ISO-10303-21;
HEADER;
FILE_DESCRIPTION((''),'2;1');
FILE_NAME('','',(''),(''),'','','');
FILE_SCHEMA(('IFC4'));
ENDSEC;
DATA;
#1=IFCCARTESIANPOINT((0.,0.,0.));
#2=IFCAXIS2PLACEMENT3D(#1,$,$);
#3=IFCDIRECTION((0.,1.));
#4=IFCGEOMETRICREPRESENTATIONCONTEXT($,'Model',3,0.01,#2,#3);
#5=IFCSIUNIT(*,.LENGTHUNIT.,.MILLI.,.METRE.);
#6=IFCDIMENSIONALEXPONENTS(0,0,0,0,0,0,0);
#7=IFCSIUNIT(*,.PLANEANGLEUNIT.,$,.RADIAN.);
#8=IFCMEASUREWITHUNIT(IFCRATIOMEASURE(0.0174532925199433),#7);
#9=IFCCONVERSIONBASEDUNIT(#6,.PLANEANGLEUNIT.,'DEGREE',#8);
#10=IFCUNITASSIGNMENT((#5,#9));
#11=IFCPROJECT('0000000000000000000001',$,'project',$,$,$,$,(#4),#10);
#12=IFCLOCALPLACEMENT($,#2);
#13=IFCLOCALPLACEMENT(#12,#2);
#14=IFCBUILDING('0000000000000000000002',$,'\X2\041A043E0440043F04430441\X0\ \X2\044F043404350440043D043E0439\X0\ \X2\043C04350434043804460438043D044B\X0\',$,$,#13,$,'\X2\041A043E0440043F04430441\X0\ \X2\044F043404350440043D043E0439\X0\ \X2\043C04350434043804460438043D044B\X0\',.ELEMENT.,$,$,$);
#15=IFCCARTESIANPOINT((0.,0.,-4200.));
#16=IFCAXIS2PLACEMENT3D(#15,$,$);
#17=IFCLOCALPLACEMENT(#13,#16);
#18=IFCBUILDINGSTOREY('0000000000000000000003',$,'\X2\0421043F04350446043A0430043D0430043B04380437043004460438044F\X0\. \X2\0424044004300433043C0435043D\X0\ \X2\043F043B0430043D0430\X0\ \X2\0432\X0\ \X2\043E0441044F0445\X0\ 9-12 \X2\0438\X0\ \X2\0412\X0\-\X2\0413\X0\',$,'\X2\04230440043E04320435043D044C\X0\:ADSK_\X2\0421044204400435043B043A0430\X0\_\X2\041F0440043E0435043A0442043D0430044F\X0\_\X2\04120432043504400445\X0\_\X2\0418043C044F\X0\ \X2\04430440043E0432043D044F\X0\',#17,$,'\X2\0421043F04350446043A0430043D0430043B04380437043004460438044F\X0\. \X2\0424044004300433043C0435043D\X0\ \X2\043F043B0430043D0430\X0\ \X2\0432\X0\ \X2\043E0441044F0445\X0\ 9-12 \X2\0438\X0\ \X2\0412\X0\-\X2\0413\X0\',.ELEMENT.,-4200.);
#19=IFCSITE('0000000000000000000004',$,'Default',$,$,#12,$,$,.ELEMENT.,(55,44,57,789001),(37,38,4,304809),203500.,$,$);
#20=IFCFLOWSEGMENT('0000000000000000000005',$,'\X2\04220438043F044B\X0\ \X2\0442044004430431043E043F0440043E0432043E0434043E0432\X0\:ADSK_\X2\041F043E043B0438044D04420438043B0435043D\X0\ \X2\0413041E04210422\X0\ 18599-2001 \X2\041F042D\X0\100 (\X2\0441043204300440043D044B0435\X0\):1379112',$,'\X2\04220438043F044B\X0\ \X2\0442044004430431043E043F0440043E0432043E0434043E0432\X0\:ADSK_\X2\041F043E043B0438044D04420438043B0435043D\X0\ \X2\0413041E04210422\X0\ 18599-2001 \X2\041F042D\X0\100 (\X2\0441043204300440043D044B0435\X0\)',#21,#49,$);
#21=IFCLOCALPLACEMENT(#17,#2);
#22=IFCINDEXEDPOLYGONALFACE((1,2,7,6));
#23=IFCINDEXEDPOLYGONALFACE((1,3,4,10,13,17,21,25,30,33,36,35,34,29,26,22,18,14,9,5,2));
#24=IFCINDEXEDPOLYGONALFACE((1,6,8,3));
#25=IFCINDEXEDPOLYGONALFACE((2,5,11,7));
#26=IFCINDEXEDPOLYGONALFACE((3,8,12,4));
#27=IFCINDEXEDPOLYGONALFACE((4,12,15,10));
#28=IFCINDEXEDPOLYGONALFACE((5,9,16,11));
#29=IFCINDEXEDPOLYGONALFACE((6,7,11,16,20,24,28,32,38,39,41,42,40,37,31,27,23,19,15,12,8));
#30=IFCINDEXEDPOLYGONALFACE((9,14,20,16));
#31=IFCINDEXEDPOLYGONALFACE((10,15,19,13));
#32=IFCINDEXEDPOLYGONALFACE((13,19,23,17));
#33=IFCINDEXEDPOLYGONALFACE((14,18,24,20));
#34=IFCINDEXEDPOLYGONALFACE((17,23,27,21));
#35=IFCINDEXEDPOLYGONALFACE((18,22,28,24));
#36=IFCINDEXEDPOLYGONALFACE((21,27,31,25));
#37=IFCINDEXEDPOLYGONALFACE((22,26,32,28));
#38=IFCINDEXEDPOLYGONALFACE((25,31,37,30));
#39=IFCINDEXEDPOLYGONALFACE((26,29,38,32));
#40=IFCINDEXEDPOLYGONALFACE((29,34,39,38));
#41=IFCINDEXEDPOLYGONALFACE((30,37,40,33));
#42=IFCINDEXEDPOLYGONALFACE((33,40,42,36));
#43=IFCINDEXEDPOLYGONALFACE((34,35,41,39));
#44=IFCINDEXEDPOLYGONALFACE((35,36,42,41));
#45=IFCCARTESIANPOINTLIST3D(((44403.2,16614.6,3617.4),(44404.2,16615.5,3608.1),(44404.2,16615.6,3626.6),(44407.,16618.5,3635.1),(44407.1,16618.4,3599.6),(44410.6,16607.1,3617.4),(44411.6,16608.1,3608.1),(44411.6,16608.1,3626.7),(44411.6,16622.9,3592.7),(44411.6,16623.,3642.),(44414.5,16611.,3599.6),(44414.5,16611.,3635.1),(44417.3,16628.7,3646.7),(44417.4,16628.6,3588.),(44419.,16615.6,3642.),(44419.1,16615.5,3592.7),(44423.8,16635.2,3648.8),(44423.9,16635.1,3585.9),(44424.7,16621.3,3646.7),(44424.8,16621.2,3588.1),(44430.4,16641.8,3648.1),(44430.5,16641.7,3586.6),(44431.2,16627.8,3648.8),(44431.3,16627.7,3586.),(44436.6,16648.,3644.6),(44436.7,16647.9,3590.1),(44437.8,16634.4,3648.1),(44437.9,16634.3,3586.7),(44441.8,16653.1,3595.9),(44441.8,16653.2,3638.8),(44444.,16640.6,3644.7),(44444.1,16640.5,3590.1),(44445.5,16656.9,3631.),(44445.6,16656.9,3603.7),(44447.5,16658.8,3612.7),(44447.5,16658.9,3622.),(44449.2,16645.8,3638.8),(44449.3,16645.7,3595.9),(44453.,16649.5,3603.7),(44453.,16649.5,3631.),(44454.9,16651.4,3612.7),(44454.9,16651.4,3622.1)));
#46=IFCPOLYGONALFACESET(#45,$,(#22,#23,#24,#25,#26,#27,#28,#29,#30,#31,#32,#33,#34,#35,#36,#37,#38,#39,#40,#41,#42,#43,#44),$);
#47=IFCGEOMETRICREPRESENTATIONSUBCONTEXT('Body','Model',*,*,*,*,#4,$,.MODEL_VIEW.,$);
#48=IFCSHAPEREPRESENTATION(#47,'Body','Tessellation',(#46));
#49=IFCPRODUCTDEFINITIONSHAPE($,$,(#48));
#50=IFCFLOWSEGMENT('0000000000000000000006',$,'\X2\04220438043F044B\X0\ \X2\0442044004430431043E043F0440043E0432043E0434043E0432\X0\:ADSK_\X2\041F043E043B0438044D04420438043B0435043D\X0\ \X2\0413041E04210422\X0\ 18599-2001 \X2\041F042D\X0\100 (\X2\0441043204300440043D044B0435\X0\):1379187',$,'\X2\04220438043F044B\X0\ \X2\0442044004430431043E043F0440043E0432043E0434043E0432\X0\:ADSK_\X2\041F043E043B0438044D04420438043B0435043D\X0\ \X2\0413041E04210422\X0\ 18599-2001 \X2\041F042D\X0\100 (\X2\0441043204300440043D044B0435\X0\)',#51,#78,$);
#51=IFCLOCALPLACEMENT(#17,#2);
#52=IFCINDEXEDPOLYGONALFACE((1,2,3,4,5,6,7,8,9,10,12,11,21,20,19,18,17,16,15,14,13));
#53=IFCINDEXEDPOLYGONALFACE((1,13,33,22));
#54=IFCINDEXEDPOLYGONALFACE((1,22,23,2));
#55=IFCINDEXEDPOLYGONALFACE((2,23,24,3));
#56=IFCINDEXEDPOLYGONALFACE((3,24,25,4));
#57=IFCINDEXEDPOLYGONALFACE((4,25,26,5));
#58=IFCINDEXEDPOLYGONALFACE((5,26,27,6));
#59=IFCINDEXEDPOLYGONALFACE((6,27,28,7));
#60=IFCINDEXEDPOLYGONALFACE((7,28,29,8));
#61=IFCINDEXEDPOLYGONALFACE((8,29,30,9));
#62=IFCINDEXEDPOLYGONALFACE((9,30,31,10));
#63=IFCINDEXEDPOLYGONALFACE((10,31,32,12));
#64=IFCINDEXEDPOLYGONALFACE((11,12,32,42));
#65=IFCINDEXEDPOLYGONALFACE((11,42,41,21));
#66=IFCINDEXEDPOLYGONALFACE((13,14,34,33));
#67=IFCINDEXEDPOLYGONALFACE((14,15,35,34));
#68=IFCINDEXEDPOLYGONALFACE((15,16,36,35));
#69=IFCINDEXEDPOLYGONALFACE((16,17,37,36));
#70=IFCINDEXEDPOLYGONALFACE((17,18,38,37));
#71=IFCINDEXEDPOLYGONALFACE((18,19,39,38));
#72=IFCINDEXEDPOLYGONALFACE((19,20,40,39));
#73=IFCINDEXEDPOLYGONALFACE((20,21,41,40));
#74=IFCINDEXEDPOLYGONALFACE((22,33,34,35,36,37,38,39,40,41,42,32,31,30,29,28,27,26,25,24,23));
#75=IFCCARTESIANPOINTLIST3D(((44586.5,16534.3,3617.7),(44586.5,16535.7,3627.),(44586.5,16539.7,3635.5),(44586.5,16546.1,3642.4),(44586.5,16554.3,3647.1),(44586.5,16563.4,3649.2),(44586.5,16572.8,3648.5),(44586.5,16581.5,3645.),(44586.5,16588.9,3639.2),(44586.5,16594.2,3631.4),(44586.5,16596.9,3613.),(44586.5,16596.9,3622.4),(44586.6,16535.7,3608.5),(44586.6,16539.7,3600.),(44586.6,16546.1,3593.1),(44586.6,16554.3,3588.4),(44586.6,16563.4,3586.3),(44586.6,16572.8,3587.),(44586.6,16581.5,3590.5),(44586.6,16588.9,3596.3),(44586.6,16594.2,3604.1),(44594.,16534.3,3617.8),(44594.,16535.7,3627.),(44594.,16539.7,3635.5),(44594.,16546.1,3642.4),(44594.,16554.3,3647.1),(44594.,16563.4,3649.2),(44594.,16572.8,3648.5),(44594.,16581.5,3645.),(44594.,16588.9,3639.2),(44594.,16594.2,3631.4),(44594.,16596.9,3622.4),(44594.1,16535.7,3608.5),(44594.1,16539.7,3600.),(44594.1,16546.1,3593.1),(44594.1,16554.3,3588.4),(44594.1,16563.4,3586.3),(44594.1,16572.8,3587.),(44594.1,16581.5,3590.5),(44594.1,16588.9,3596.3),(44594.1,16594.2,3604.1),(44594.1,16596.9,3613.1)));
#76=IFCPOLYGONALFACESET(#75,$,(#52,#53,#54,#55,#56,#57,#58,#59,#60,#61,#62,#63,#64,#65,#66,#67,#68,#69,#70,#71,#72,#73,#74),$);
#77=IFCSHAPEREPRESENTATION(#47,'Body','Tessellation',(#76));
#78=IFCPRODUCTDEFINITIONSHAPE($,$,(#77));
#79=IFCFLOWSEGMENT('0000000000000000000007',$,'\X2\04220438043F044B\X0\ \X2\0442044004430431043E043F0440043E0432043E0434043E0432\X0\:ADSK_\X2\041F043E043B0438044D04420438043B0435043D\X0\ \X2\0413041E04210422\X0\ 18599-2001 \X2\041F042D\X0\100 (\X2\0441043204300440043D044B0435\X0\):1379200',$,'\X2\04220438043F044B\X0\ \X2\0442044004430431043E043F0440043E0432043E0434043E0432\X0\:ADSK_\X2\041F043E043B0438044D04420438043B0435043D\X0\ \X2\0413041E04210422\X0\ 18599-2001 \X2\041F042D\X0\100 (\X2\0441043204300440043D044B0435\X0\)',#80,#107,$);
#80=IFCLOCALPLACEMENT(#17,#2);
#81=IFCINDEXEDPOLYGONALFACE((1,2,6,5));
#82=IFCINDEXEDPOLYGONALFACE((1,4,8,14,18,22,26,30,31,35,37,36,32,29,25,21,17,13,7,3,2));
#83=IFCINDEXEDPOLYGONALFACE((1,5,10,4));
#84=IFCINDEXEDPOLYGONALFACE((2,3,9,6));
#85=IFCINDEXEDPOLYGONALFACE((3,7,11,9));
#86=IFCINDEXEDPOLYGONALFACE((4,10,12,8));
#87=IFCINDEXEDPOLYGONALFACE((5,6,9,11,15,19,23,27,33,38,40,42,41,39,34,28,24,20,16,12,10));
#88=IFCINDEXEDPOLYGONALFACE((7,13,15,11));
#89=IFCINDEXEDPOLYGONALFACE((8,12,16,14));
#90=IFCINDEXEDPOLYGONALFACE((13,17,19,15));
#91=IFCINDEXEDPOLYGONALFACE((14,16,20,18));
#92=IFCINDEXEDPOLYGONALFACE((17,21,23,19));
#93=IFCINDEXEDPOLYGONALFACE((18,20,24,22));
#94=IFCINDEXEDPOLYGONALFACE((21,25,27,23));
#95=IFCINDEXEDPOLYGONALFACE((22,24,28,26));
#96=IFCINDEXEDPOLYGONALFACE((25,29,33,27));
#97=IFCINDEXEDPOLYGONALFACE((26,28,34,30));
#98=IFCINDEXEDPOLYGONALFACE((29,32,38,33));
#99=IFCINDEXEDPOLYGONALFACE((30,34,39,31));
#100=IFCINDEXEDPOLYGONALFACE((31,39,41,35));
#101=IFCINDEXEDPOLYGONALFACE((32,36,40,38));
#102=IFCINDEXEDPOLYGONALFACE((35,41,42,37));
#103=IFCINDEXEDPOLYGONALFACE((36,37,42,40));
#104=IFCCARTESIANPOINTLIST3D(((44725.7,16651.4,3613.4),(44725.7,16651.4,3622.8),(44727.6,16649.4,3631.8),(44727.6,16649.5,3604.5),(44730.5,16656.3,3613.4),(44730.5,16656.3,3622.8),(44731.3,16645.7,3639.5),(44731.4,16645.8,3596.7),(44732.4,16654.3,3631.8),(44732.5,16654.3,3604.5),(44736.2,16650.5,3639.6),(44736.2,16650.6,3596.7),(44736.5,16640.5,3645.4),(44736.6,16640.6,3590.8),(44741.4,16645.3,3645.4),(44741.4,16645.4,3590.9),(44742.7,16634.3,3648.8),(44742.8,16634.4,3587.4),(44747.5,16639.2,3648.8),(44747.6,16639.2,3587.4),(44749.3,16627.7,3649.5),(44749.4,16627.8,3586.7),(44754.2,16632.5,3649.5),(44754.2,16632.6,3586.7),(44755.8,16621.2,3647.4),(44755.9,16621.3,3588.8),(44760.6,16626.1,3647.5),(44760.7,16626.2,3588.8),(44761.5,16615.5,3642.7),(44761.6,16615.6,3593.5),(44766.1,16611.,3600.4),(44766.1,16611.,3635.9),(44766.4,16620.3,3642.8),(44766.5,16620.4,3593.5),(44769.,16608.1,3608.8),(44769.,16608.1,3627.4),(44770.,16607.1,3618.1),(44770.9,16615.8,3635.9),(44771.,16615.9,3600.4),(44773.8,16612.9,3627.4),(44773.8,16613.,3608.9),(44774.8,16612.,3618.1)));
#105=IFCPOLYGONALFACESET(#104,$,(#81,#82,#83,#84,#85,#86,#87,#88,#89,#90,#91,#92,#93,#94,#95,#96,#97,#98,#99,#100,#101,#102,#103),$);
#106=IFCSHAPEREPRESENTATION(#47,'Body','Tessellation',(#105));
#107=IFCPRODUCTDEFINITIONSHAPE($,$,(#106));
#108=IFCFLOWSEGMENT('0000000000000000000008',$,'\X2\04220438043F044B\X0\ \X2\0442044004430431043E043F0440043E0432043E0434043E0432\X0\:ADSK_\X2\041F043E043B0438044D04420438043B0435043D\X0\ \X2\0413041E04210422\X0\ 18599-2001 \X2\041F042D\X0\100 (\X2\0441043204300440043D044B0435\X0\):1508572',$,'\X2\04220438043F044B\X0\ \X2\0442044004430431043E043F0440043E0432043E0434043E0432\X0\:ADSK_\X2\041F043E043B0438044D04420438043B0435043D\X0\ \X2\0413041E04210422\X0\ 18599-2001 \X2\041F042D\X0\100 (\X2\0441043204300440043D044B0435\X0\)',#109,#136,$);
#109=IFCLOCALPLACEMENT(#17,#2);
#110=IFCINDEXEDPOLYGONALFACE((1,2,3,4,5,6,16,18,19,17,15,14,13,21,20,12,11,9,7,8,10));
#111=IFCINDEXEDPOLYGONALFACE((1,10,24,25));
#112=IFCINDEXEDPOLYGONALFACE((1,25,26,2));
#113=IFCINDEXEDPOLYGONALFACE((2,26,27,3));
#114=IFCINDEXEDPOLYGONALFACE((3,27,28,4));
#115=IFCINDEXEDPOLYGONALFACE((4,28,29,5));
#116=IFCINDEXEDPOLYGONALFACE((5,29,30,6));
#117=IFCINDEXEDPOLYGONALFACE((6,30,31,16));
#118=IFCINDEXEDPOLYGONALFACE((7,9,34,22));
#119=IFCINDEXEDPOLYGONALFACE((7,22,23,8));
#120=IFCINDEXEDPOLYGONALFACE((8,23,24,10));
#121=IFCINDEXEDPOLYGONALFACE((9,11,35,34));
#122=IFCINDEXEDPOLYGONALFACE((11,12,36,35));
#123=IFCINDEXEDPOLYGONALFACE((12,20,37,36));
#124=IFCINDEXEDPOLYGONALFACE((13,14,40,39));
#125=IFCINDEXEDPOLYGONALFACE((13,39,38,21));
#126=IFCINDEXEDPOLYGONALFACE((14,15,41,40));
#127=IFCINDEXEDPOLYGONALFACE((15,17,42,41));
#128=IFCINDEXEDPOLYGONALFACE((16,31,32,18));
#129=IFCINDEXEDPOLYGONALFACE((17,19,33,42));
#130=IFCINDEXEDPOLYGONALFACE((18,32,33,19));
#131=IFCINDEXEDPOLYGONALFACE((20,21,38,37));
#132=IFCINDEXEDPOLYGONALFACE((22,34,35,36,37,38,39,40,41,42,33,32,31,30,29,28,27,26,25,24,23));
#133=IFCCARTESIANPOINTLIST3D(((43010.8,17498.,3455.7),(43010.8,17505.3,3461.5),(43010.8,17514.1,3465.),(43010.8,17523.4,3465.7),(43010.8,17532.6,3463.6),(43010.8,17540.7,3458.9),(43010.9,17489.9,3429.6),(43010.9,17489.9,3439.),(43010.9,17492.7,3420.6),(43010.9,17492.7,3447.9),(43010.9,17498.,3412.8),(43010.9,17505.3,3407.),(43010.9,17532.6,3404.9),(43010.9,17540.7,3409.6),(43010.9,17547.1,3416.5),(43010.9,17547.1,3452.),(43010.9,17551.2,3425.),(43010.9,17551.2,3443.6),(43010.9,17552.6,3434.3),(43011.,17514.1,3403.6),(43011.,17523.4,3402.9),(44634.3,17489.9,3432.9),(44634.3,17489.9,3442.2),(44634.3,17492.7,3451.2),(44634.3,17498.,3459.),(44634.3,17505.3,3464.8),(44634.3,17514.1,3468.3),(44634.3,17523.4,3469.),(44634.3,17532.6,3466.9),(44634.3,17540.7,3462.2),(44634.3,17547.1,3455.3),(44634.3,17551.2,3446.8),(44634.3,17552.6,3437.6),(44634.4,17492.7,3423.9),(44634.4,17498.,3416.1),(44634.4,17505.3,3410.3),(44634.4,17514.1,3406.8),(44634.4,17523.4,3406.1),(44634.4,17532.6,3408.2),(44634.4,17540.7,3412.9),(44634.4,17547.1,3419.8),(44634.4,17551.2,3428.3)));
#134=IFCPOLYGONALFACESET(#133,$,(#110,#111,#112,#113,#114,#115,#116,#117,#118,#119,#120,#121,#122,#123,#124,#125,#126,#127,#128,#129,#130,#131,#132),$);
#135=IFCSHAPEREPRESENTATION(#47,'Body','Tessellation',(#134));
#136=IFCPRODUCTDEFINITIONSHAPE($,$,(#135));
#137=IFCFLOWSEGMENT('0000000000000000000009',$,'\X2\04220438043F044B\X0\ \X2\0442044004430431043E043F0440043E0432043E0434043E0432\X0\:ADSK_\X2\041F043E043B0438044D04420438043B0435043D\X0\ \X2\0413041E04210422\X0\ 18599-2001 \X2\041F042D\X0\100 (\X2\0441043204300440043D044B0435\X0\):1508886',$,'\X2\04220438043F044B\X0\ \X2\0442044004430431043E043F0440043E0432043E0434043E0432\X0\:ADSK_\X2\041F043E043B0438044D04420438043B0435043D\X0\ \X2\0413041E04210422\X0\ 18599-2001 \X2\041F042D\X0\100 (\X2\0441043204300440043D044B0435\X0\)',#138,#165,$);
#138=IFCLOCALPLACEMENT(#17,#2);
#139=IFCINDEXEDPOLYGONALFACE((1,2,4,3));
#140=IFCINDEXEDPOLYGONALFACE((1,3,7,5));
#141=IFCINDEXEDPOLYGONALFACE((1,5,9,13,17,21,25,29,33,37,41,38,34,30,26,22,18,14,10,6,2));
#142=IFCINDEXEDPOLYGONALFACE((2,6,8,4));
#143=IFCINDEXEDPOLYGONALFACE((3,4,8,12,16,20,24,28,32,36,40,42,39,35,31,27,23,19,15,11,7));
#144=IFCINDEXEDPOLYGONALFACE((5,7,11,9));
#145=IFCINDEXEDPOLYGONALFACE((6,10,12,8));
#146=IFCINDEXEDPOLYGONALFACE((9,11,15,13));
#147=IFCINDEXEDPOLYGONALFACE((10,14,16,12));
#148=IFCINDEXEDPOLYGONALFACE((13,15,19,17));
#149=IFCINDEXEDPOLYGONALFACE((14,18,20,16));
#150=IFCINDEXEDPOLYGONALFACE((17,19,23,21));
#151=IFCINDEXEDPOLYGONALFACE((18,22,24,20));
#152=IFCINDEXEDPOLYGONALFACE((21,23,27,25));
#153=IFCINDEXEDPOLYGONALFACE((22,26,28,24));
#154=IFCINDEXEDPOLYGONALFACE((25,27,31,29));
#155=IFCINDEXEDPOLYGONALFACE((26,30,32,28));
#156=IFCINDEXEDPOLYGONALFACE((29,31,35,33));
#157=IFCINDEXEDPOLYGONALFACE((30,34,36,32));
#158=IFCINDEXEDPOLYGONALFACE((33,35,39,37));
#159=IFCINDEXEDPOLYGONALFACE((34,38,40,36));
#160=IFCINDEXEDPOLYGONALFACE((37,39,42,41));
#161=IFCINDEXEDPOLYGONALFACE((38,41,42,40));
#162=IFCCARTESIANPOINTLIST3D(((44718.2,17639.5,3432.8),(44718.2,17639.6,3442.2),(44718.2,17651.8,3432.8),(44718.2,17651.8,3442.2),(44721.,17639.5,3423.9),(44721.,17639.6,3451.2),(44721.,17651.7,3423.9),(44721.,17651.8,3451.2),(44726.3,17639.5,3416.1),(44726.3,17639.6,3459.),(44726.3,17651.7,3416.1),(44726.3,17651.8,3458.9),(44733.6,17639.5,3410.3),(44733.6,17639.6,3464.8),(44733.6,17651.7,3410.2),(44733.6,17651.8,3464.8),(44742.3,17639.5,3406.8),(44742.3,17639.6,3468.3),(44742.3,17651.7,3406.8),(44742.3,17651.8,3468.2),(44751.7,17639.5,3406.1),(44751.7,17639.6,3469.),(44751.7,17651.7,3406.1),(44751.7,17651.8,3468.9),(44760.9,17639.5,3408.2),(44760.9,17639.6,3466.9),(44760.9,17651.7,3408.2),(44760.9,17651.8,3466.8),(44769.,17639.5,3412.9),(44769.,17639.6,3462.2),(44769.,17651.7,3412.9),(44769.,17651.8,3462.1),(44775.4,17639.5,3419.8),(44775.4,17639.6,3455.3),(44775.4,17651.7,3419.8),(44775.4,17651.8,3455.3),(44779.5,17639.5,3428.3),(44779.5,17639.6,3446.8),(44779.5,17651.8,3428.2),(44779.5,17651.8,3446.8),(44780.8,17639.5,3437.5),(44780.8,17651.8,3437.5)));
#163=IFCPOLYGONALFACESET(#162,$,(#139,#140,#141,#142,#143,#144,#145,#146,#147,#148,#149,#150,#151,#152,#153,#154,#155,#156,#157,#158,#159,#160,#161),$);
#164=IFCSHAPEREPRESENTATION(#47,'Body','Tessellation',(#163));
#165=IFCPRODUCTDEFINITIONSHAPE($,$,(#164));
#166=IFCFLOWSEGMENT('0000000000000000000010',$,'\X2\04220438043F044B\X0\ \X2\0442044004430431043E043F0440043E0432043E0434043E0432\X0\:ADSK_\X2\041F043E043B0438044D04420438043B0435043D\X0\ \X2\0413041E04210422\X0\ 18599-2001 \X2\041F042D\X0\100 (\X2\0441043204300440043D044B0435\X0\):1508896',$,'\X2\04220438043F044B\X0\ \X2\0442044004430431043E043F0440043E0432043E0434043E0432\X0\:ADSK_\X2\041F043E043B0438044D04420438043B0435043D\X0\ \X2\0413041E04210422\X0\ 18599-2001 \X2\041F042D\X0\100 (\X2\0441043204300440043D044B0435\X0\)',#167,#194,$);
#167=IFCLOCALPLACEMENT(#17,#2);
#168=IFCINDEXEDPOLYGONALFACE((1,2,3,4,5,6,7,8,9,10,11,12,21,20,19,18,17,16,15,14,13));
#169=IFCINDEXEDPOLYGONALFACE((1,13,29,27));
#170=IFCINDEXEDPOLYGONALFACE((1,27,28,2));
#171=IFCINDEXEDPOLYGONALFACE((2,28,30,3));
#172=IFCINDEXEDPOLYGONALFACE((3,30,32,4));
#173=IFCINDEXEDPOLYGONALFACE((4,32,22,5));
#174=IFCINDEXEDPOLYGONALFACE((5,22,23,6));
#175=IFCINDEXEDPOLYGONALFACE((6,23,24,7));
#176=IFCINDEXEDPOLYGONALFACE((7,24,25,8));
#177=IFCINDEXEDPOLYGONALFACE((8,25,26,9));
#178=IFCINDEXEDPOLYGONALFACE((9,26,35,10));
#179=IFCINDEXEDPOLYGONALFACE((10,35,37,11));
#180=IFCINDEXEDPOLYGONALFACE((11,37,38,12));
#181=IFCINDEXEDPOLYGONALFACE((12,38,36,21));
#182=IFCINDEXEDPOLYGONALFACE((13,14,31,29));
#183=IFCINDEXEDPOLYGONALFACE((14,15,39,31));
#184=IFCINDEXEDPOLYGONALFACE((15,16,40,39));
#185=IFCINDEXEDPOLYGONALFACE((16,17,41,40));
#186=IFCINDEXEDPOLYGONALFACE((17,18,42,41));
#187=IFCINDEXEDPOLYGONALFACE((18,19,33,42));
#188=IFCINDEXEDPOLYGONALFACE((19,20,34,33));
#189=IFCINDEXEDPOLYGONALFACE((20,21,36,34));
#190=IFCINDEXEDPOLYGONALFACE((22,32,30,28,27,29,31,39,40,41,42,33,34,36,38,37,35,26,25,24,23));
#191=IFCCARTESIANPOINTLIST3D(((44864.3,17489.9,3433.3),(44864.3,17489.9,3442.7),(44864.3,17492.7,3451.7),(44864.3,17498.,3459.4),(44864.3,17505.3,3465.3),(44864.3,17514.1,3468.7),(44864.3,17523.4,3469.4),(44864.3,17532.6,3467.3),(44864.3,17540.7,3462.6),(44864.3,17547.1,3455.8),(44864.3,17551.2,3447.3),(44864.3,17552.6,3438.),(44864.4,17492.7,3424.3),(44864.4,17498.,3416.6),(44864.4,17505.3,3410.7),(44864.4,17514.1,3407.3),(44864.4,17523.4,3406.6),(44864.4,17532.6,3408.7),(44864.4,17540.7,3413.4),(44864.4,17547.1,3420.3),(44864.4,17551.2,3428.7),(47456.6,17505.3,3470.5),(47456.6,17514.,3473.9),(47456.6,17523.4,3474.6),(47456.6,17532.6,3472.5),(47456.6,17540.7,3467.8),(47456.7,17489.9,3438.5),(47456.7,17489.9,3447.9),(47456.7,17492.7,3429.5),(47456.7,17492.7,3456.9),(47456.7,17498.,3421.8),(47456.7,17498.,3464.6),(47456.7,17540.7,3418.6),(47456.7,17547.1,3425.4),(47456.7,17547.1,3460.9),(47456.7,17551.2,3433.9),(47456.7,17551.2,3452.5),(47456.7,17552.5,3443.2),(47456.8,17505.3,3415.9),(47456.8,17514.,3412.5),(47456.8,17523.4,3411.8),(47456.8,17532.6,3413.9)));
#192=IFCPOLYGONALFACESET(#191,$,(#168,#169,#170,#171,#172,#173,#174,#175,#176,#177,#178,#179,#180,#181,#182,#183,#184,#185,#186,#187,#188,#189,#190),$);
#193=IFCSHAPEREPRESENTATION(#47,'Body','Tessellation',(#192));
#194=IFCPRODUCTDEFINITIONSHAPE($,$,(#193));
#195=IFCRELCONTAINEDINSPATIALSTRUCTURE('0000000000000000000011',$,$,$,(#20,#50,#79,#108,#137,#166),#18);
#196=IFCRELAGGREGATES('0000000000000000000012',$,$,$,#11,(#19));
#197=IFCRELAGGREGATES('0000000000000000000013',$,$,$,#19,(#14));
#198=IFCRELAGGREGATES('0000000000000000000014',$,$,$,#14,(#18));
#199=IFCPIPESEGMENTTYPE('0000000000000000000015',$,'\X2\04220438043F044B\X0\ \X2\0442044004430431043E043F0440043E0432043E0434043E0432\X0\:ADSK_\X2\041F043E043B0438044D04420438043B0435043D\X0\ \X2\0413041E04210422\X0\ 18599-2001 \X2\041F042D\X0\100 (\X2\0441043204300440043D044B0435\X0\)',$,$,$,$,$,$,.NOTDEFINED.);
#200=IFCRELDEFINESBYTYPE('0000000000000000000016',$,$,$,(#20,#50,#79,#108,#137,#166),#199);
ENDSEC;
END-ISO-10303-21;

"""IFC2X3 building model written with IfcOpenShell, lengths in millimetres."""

from ifc_helpers import new_model, entity, si_unit, converted_unit, direction, frame, origin, origin_2d_with_axis, place, context, subcontext, project, spatial, circle, extrude, type_object, element, save


model = new_model("IFC2X3")

# Units and contexts
model_context = context("Model", 3, precision=0.01, world=origin(), true_north=direction((0.0, 1.0)))
body_context = subcontext(model_context, "Body", "Model", "MODEL_VIEW")
ifc_project = project(units=[si_unit("LENGTHUNIT", "METRE", prefix="MILLI"), converted_unit("PLANEANGLEUNIT", "DEGREE", entity("IfcRatioMeasure", 0.0174532925199433), si_unit("PLANEANGLEUNIT", "RADIAN"), dimensions=[0, 0, 0, 0, 0, 0, 0])], contexts=[model_context])

# Site, building, storey
site_placement = place(None, origin())
site = spatial("IfcSite", under=ifc_project, at=site_placement, Name="Default", CompositionType="ELEMENT", RefLatitude=(55, 44, 57, 789001), RefLongitude=(37, 38, 4, 304809), RefElevation=203500.0)
building_placement = place(site_placement, origin())
building = spatial("IfcBuilding", under=site, at=building_placement, Name="Корпус ядерной медицины", LongName="Корпус ядерной медицины", CompositionType="ELEMENT")
storey_placement = place(building_placement, frame((0.0, 0.0, -4200.0)))
storey = spatial("IfcBuildingStorey", under=building, at=storey_placement, Name="Спецканализация. Фрагмен плана в осях 9-12 и В-Г", ObjectType="Уровень:ADSK_Стрелка_Проектная_Вверх_Имя уровня", LongName="Спецканализация. Фрагмен плана в осях 9-12 и В-Г", CompositionType="ELEMENT", Elevation=-4200.0)

# Flow segments
pipe_segment_type = type_object("IfcPipeSegmentType", Name="Типы трубопроводов:ADSK_Полиэтилен ГОСТ 18599-2001 ПЭ100 (сварные)", PredefinedType="NOTDEFINED")
flow_segment_1_placement = place(storey_placement, frame((44401.6, 16605.5, 3584.2)))
element("IfcFlowSegment", 1, at=flow_segment_1_placement, inside=storey, type_object=pipe_segment_type, Name="Типы трубопроводов:ADSK_Полиэтилен ГОСТ 18599-2001 ПЭ100 (сварные):1379112", ObjectType="Типы трубопроводов:ADSK_Полиэтилен ГОСТ 18599-2001 ПЭ100 (сварные)", context=body_context, shape_type="SweptSolid", body=[
    extrude(circle(Radius=31.5, at=origin_2d_with_axis()), frame((23.9, 31.3, 33.1), z_axis=(0.707106, -0.707104, 0.002144), x_axis=(-0.707105, -0.707108, 0.0)), (0.0, 0.0, 1.0), 10.5),
])
flow_segment_2_placement = place(storey_placement, frame((44586.5, 16532.7, 3584.6)))
element("IfcFlowSegment", 2, at=flow_segment_2_placement, inside=storey, type_object=pipe_segment_type, Name="Типы трубопроводов:ADSK_Полиэтилен ГОСТ 18599-2001 ПЭ100 (сварные):1379187", ObjectType="Типы трубопроводов:ADSK_Полиэтилен ГОСТ 18599-2001 ПЭ100 (сварные)", context=body_context, shape_type="SweptSolid", body=[
    extrude(circle(Radius=31.5, at=origin_2d_with_axis()), frame((0.1, 33.1, 33.1), z_axis=(0.999998, 0.0, 0.002), x_axis=(0.0, -1.0, 0.0)), (0.0, 0.0, 1.0), 7.5),
])
flow_segment_3_placement = place(storey_placement, frame((44723.8, 16605.5, 3585.0)))
element("IfcFlowSegment", 3, at=flow_segment_3_placement, inside=storey, type_object=pipe_segment_type, Name="Типы трубопроводов:ADSK_Полиэтилен ГОСТ 18599-2001 ПЭ100 (сварные):1379200", ObjectType="Типы трубопроводов:ADSK_Полиэтилен ГОСТ 18599-2001 ПЭ100 (сварные)", context=body_context, shape_type="SweptSolid", body=[
    extrude(circle(Radius=31.5, at=origin_2d_with_axis()), frame((23.9, 23.9, 33.1), z_axis=(0.707105, 0.707105, 0.002179), x_axis=(0.707107, -0.707107, 0.0)), (0.0, 0.0, 1.0), 6.9),
])
flow_segment_4_placement = place(storey_placement, frame((43010.8, 17488.0, 3401.2)))
element("IfcFlowSegment", 4, at=flow_segment_4_placement, inside=storey, type_object=pipe_segment_type, Name="Типы трубопроводов:ADSK_Полиэтилен ГОСТ 18599-2001 ПЭ100 (сварные):1508572", ObjectType="Типы трубопроводов:ADSK_Полиэтилен ГОСТ 18599-2001 ПЭ100 (сварные)", context=body_context, shape_type="SweptSolid", body=[
    extrude(circle(Radius=31.5, at=origin_2d_with_axis()), frame((0.1, 33.1, 33.1), z_axis=(0.999998, 0.0, 0.002023), x_axis=(0.0, 1.0, 0.0)), (0.0, 0.0, 1.0), 1623.4),
])
flow_segment_5_placement = place(storey_placement, frame((44716.2, 17639.5, 3404.4)))
element("IfcFlowSegment", 5, at=flow_segment_5_placement, inside=storey, type_object=pipe_segment_type, Name="Типы трубопроводов:ADSK_Полиэтилен ГОСТ 18599-2001 ПЭ100 (сварные):1508886", ObjectType="Типы трубопроводов:ADSK_Полиэтилен ГОСТ 18599-2001 ПЭ100 (сварные)", context=body_context, shape_type="SweptSolid", body=[
    extrude(circle(Radius=31.5, at=origin_2d_with_axis()), frame((33.1, 12.3, 33.1), z_axis=(-0.000008, -0.999998, 0.002), x_axis=(1.0, -0.000008, 0.0)), (0.0, 0.0, 1.0), 12.2),
])
flow_segment_6_placement = place(storey_placement, frame((44864.3, 17488.0, 3404.9)))
element("IfcFlowSegment", 6, at=flow_segment_6_placement, inside=storey, type_object=pipe_segment_type, Name="Типы трубопроводов:ADSK_Полиэтилен ГОСТ 18599-2001 ПЭ100 (сварные):1508896", ObjectType="Типы трубопроводов:ADSK_Полиэтилен ГОСТ 18599-2001 ПЭ100 (сварные)", context=body_context, shape_type="SweptSolid", body=[
    extrude(circle(Radius=31.5, at=origin_2d_with_axis()), frame((0.1, 33.1, 33.1), z_axis=(0.999998, -0.000004, 0.001999), x_axis=(0.000004, 1.0, 0.0)), (0.0, 0.0, 1.0), 2592.4),
])

save(model, "model.ifc")
